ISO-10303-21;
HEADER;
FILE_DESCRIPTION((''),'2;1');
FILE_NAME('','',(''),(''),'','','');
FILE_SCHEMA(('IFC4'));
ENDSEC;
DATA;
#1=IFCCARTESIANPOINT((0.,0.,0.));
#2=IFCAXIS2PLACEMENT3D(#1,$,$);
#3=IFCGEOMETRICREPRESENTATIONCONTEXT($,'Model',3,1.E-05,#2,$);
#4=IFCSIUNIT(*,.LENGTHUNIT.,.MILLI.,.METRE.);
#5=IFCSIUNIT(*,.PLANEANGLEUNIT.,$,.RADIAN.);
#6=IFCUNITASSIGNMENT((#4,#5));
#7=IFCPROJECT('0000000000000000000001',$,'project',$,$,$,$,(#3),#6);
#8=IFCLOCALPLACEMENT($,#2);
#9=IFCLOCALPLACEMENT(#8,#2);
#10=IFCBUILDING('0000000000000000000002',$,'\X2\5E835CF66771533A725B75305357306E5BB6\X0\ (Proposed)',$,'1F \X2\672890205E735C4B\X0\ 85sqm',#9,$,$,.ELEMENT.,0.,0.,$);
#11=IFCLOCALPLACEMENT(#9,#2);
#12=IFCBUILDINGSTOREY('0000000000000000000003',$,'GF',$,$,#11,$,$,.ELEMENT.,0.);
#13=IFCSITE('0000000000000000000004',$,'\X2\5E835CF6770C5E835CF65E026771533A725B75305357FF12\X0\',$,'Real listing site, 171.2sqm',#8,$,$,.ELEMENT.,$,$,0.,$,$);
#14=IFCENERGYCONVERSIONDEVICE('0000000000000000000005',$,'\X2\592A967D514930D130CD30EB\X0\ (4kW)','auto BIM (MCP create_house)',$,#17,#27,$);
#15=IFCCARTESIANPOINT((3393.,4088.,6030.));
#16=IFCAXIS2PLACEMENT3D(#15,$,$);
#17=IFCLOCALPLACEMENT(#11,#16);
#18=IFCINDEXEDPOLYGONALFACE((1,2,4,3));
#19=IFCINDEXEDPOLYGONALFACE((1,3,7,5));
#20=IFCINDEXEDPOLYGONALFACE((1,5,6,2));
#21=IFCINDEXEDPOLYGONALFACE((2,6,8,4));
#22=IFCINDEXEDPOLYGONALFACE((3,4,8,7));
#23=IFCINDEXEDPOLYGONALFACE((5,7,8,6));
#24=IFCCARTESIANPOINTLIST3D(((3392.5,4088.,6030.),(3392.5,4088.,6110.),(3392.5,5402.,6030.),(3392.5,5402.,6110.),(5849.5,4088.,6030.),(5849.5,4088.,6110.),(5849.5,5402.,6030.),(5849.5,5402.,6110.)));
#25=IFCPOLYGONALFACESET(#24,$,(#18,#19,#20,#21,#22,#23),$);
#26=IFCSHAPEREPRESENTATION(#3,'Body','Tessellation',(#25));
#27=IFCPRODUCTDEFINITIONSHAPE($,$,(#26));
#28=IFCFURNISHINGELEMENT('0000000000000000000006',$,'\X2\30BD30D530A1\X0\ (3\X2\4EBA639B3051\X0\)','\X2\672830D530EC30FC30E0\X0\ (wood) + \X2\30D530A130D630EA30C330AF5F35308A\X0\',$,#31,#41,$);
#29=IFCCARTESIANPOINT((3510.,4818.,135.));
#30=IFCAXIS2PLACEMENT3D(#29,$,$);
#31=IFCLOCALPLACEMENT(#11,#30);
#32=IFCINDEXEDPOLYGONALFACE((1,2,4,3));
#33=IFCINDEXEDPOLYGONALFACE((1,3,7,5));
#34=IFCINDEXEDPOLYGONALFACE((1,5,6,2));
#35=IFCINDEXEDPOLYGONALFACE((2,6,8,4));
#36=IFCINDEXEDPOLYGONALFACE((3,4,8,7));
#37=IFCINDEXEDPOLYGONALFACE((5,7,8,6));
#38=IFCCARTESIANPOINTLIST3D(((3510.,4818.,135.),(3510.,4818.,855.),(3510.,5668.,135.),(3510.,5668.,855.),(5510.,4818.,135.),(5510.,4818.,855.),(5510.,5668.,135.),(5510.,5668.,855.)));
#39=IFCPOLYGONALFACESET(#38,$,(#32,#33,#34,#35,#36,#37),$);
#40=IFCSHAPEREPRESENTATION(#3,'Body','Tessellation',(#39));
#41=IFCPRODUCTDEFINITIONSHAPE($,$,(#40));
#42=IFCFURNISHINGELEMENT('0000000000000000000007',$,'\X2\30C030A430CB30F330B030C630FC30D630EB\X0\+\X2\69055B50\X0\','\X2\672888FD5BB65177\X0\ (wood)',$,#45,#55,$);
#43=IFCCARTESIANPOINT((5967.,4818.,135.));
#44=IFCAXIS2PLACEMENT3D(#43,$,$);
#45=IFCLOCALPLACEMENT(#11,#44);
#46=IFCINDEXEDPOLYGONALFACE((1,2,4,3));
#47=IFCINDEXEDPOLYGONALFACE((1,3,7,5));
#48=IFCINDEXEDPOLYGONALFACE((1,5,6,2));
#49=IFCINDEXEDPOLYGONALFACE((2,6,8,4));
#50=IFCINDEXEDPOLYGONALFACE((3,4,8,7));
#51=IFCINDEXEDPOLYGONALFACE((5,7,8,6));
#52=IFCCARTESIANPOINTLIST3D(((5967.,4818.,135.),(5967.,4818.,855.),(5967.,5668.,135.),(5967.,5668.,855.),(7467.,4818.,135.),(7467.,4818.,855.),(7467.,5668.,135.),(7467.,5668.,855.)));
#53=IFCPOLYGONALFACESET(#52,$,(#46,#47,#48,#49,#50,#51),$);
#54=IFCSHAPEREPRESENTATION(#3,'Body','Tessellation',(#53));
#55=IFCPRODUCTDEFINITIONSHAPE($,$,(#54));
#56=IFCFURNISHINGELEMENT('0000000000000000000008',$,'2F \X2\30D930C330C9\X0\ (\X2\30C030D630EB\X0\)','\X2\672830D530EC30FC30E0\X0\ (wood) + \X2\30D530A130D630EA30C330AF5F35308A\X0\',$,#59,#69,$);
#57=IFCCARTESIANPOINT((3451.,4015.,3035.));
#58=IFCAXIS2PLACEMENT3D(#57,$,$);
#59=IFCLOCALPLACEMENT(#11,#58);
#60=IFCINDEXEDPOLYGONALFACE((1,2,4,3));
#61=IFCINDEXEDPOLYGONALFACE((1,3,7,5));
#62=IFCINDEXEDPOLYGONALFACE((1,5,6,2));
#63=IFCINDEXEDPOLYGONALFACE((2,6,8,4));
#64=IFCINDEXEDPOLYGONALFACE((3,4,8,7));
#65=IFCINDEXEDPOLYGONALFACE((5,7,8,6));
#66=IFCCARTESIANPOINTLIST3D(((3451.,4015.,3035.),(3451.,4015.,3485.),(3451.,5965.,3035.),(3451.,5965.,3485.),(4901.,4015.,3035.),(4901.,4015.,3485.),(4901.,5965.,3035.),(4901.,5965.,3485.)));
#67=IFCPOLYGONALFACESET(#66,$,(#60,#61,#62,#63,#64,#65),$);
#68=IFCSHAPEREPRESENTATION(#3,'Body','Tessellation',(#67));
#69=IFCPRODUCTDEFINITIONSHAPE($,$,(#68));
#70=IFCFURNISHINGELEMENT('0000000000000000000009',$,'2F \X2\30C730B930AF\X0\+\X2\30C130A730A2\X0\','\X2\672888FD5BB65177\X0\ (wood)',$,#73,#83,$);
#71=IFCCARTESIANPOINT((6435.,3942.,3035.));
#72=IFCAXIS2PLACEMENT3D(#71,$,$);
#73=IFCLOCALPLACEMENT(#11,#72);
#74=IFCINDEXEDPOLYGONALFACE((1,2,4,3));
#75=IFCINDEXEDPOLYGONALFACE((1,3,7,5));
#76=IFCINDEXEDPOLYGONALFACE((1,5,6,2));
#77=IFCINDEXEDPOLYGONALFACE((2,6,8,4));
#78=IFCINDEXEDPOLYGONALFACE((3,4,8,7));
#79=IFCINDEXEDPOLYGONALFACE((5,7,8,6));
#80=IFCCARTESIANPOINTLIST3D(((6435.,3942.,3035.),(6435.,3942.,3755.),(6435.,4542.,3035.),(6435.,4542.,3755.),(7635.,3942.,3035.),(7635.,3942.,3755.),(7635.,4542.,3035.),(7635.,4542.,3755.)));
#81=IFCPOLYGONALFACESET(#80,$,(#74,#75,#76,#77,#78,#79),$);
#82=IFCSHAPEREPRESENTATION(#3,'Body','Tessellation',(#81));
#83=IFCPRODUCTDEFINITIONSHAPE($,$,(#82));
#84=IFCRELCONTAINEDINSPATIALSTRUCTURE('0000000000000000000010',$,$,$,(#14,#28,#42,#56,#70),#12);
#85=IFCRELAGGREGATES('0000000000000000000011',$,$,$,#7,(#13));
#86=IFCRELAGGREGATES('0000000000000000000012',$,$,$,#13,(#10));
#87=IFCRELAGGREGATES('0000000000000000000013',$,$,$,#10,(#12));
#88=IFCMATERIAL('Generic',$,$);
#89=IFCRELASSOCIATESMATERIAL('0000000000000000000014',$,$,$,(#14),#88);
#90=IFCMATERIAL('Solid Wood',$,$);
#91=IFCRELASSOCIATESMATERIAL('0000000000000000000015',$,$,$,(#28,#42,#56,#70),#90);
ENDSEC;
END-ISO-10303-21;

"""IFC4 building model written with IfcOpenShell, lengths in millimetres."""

from ifc_helpers import new_model, si_unit, frame, frame_2d, origin, place, context, project, spatial, rectangle, extrude, material, element, save


model = new_model("IFC4")

# Units and contexts
model_context = context("Model", 3, precision=1e-05, world=origin())
ifc_project = project(units=[si_unit("LENGTHUNIT", "METRE", prefix="MILLI"), si_unit("PLANEANGLEUNIT", "RADIAN")], contexts=[model_context])

# Site, building, storey
site_placement = place(None, origin())
site = spatial("IfcSite", under=ifc_project, at=site_placement, Name="広島県広島市東区牛田南２", ObjectType="Real listing site, 171.2sqm", CompositionType="ELEMENT", RefElevation=0.0)
building_placement = place(site_placement, origin())
building = spatial("IfcBuilding", under=site, at=building_placement, Name="広島東区牛田南の家 (Proposed)", ObjectType="1F 木造平屋 85sqm", CompositionType="ELEMENT", ElevationOfRefHeight=0.0, ElevationOfTerrain=0.0)
storey_placement = place(building_placement, origin())
storey = spatial("IfcBuildingStorey", under=building, at=storey_placement, Name="GF", CompositionType="ELEMENT", Elevation=0.0)

# Shared definitions
ifc_material_1 = material(Name="Solid Wood")

# Shared definitions
ifc_material_2 = material(Name="Generic")

# Energy conversion device
energy_conversion_device_placement = place(storey_placement, frame((3393.0, 4088.0, 6030.0)))
element("IfcEnergyConversionDevice", 1, at=energy_conversion_device_placement, inside=storey, material=ifc_material_2, Name="太陽光パネル (4kW)", Description="auto BIM (MCP create_house)", context=model_context, shape_type="SweptSolid", body=[
    extrude(rectangle(XDim=2457.0, YDim=1314.0, at=frame_2d((1228.0, 657.0))), frame((3393.0, 4088.0, 6030.0)), (0.0, 0.0, 1.0), 80.0),
])

# Furnishing elements
furnishing_1_placement = place(storey_placement, frame((3510.0, 4818.0, 135.0)))
element("IfcFurnishingElement", 2, at=furnishing_1_placement, inside=storey, material=ifc_material_1, Name="ソファ (3人掛け)", Description="木フレーム (wood) + ファブリック張り", context=model_context, shape_type="SweptSolid", body=[
    extrude(rectangle(XDim=2000.0, YDim=850.0, at=frame_2d((1000.0, 425.0))), frame((3510.0, 4818.0, 135.0)), (0.0, 0.0, 1.0), 720.0),
])
furnishing_2_placement = place(storey_placement, frame((5967.0, 4818.0, 135.0)))
element("IfcFurnishingElement", 3, at=furnishing_2_placement, inside=storey, material=ifc_material_1, Name="ダイニングテーブル+椅子", Description="木製家具 (wood)", context=model_context, shape_type="SweptSolid", body=[
    extrude(rectangle(XDim=1500.0, YDim=850.0, at=frame_2d((750.0, 425.0))), frame((5967.0, 4818.0, 135.0)), (0.0, 0.0, 1.0), 720.0),
])
furnishing_3_placement = place(storey_placement, frame((3451.0, 4015.0, 3035.0)))
element("IfcFurnishingElement", 4, at=furnishing_3_placement, inside=storey, material=ifc_material_1, Name="2F ベッド (ダブル)", Description="木フレーム (wood) + ファブリック張り", context=model_context, shape_type="SweptSolid", body=[
    extrude(rectangle(XDim=1450.0, YDim=1950.0, at=frame_2d((725.0, 975.0))), frame((3451.0, 4015.0, 3035.0)), (0.0, 0.0, 1.0), 450.0),
])
furnishing_4_placement = place(storey_placement, frame((6435.0, 3942.0, 3035.0)))
element("IfcFurnishingElement", 5, at=furnishing_4_placement, inside=storey, material=ifc_material_1, Name="2F デスク+チェア", Description="木製家具 (wood)", context=model_context, shape_type="SweptSolid", body=[
    extrude(rectangle(XDim=1200.0, YDim=600.0, at=frame_2d((600.0, 300.0))), frame((6435.0, 3942.0, 3035.0)), (0.0, 0.0, 1.0), 720.0),
])

save(model, "model.ifc")
